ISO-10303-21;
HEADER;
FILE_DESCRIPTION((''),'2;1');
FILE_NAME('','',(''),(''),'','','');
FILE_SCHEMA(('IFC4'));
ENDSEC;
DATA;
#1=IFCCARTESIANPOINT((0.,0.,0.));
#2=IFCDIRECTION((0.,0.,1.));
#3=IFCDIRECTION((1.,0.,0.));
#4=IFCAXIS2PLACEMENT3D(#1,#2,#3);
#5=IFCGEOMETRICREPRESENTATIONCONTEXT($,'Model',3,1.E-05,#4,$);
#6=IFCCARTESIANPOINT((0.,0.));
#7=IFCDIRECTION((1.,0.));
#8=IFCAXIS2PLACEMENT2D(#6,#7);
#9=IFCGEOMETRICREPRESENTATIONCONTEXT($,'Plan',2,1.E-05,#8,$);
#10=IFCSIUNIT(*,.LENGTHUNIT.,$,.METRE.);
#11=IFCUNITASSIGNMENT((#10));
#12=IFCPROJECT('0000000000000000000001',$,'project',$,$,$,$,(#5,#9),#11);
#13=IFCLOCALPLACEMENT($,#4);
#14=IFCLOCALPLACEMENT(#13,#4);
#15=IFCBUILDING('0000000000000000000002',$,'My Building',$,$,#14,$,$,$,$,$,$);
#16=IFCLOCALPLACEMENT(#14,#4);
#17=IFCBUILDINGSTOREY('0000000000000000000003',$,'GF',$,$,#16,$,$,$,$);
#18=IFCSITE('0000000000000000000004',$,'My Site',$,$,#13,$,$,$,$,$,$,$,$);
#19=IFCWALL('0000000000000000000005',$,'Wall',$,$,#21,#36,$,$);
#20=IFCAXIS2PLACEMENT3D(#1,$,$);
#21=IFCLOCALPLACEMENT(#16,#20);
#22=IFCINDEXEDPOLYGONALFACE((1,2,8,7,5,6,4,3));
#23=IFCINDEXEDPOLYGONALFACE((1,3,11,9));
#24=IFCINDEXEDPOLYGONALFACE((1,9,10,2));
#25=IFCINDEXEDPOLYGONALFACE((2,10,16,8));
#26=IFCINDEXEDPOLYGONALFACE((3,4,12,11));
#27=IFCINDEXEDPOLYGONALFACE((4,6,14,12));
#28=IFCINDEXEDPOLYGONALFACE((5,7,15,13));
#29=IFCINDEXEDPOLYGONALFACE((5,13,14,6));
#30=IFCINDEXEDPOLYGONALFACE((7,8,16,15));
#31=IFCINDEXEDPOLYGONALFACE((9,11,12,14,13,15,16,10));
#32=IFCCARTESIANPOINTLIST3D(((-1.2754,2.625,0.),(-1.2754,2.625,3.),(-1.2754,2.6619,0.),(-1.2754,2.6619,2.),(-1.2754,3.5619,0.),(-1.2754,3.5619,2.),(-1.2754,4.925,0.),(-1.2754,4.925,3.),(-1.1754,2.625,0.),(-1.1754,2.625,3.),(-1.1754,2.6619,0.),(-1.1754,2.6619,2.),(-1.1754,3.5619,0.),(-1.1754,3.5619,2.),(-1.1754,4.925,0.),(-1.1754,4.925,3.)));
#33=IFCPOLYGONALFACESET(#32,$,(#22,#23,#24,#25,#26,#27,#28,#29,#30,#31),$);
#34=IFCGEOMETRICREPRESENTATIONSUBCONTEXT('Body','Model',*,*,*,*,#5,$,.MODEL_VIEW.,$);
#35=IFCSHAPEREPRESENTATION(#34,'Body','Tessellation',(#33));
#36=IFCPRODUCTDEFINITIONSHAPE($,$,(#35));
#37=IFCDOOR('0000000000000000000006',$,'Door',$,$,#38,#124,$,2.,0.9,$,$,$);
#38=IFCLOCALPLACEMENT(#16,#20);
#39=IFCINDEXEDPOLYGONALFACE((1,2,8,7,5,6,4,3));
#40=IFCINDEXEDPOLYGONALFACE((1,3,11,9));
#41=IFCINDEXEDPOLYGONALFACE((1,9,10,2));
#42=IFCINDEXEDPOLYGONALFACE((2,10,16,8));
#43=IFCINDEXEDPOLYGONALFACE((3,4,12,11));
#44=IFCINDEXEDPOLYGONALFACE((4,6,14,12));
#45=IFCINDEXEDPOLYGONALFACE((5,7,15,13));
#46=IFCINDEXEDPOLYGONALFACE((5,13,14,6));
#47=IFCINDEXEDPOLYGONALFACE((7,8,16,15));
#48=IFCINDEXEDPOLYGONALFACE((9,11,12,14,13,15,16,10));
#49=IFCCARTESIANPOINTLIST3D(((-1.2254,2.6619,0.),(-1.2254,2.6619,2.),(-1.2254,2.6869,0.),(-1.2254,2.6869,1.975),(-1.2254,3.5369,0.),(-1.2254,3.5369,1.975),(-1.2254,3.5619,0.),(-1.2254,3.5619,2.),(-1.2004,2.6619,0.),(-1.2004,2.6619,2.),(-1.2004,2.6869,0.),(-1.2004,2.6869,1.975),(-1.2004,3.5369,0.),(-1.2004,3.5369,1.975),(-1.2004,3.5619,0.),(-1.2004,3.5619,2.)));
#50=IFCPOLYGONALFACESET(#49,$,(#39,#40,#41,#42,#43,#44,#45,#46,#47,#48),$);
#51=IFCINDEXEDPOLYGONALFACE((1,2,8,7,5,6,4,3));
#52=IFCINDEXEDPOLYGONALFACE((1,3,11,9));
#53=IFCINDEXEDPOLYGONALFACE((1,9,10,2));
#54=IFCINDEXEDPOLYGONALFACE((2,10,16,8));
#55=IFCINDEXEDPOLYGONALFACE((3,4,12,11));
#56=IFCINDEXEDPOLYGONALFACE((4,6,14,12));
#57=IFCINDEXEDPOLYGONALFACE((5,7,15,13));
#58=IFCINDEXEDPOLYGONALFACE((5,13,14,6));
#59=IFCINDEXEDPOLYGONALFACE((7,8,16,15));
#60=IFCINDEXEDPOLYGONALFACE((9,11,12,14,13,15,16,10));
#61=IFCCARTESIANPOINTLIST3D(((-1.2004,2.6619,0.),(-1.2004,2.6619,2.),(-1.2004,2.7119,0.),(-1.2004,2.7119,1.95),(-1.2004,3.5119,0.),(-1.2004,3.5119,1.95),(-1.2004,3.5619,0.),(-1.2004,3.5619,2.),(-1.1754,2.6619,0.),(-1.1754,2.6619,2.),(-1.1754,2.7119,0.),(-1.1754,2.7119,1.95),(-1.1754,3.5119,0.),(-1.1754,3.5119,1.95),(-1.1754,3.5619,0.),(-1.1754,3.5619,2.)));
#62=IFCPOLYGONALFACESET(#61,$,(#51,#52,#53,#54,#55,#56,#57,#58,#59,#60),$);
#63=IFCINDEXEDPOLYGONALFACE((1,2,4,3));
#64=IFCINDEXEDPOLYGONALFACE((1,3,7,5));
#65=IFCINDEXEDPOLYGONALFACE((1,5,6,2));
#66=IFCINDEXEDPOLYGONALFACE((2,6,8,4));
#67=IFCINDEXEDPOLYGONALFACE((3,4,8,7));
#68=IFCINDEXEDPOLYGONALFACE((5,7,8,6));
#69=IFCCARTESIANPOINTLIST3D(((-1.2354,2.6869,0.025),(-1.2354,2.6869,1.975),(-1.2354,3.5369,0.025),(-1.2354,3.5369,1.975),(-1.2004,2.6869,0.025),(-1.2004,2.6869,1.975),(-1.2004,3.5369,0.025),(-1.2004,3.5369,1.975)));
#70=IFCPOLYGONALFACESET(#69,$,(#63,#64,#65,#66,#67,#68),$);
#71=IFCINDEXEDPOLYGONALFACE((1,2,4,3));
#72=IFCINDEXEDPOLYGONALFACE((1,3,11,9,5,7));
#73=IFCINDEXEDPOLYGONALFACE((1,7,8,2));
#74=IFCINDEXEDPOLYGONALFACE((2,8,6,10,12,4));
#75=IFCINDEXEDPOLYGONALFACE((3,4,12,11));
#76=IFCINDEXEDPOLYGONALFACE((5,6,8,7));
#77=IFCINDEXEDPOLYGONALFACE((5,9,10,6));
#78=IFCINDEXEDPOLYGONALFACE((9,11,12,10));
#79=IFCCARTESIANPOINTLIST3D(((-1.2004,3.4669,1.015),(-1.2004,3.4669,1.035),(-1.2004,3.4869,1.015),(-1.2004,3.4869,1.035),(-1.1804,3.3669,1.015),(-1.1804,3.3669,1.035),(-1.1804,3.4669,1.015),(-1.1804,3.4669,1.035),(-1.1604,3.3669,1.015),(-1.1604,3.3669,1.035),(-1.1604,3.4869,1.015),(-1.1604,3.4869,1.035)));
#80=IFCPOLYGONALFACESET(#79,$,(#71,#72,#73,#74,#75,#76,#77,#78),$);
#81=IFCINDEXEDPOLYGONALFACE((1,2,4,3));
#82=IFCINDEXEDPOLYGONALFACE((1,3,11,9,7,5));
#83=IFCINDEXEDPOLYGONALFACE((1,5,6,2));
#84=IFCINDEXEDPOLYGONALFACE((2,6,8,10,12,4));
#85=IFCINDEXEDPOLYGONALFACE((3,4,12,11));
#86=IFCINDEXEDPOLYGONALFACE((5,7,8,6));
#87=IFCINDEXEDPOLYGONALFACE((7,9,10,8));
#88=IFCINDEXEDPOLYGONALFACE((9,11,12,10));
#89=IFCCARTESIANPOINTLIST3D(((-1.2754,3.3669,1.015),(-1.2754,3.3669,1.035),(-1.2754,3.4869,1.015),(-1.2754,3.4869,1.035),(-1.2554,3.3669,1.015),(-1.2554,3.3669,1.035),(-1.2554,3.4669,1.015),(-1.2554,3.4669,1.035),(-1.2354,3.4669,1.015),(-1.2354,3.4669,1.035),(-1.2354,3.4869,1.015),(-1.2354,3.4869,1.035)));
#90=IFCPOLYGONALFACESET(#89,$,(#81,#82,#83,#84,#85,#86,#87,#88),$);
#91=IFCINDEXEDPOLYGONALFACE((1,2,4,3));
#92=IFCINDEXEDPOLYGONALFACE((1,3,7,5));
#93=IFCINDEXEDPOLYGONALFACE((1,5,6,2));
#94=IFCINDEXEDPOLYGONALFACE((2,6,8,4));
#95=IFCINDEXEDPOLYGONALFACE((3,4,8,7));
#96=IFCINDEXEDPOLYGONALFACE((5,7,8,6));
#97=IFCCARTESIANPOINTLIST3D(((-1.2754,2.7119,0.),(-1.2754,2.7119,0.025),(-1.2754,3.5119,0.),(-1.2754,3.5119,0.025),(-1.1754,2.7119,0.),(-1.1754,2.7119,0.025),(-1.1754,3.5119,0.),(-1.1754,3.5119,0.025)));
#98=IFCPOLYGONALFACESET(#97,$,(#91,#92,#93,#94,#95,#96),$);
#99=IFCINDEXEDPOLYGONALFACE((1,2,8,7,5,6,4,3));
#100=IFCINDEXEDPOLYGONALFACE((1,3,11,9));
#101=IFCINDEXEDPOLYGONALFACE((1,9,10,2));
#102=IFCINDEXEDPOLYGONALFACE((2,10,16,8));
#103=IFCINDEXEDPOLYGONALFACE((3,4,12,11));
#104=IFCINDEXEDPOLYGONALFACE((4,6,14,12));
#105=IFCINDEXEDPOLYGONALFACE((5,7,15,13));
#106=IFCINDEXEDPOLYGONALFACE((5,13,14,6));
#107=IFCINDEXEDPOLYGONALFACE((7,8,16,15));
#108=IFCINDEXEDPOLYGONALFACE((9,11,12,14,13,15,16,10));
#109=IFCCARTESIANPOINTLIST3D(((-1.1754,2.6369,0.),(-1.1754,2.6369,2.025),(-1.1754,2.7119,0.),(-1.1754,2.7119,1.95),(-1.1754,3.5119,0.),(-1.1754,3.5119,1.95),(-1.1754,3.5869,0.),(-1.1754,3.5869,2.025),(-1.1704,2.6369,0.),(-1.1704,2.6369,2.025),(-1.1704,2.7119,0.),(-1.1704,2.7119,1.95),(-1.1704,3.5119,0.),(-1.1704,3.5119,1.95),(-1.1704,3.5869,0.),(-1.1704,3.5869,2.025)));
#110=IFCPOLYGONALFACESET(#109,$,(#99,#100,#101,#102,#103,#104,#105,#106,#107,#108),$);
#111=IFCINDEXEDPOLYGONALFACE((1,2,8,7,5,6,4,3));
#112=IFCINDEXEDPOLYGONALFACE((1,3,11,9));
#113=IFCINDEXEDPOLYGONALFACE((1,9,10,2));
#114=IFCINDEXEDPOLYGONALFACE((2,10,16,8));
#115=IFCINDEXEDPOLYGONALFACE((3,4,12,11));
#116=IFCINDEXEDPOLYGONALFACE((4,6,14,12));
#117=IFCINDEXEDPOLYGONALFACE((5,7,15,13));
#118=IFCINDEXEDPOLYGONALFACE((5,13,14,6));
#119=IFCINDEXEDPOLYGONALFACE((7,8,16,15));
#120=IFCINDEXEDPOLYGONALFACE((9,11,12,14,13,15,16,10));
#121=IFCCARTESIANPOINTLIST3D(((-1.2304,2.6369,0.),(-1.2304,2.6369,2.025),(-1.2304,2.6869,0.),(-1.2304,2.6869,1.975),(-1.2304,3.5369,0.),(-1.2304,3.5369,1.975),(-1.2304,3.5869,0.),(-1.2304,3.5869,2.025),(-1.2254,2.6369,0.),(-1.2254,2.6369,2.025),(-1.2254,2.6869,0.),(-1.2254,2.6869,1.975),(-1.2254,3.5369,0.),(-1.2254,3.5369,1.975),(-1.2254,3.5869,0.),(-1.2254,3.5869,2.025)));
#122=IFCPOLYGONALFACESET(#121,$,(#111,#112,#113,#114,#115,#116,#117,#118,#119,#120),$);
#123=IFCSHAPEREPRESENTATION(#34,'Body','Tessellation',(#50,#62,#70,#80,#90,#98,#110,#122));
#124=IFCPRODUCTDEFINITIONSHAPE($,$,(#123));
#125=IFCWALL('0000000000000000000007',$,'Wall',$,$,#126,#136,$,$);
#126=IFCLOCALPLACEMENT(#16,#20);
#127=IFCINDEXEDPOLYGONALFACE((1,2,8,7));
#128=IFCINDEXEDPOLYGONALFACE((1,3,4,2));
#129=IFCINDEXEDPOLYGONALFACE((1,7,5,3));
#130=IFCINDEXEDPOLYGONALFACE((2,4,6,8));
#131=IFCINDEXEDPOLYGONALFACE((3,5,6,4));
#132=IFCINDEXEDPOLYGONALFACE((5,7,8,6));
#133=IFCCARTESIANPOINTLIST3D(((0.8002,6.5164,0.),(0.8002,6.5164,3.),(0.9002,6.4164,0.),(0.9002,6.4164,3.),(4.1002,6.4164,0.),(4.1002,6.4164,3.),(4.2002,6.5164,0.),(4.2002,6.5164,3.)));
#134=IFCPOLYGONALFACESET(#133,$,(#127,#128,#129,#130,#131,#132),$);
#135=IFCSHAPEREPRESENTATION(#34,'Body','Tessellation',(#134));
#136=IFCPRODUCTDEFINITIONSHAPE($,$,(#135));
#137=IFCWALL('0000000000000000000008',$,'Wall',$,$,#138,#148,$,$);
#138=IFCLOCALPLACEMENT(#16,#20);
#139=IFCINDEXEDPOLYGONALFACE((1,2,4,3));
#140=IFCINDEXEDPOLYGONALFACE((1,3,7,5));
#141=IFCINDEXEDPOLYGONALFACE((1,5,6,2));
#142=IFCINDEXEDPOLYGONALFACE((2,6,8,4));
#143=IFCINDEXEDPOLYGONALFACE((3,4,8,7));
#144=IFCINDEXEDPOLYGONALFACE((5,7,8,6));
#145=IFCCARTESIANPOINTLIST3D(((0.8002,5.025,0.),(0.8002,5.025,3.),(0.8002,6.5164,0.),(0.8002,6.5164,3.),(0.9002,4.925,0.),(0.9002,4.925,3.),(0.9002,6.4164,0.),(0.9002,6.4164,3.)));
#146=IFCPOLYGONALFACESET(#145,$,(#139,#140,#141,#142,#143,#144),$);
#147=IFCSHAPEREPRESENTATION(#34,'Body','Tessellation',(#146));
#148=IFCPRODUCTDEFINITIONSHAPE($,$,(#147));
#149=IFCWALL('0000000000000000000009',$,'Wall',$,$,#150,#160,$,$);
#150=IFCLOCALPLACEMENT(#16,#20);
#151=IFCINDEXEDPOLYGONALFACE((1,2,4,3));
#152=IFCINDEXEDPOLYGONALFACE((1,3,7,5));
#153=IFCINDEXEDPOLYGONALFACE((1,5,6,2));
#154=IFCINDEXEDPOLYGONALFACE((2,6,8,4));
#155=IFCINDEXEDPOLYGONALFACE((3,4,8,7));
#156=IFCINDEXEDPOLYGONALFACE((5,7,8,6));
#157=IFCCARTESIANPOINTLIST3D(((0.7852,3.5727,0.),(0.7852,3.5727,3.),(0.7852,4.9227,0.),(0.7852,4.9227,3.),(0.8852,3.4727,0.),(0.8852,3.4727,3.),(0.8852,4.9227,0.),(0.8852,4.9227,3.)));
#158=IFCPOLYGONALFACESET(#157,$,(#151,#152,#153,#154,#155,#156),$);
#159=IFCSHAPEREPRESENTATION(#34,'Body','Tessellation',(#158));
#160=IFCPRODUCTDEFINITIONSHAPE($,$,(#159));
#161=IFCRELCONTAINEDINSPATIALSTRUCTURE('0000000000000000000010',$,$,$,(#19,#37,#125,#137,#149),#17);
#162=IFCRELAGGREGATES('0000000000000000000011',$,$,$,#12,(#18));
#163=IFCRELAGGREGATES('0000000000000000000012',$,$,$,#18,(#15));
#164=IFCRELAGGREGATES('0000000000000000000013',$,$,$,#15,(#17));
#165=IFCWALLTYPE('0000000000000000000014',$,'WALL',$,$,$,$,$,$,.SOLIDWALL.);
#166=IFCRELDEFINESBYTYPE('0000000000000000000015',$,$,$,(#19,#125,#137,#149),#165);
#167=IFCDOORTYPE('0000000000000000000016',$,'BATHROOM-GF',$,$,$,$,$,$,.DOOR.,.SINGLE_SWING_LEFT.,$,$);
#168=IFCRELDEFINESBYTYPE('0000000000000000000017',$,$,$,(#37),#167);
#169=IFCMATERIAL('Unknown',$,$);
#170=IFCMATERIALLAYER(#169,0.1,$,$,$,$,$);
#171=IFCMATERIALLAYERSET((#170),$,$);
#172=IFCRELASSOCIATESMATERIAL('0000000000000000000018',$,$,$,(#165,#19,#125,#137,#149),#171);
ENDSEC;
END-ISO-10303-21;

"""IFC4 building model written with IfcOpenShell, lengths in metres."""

from ifc_helpers import new_model, entity, si_unit, frame, origin_with_axes, origin_2d_with_axis, place, context, subcontext, project, spatial, line, indexed_curve, outline, extrude, shape, source, transform, mapped, material, layer, layer_set, layer_usage, type_object, type_shapes, element, fill, save


model = new_model("IFC4")

# Units and contexts
model_context = context("Model", 3, precision=1e-05, world=origin_with_axes())
plan_context = context("Plan", 2, precision=1e-05, world=origin_2d_with_axis())
body_context_1 = subcontext(model_context, "Body", "Model", "MODEL_VIEW")
body_context_2 = subcontext(plan_context, "Body", "Plan", "PLAN_VIEW")
ifc_project = project(units=[si_unit("LENGTHUNIT", "METRE")], contexts=[model_context, plan_context])

# Site, building, storey
site_placement = place(None, origin_with_axes())
site = spatial("IfcSite", under=ifc_project, at=site_placement, Name="My Site")
building_placement = place(site_placement, origin_with_axes())
building = spatial("IfcBuilding", under=site, at=building_placement, Name="My Building")
storey_placement = place(building_placement, origin_with_axes())
storey = spatial("IfcBuildingStorey", under=building, at=storey_placement, Name="GF")

# Shared definitions
ifc_material_1 = material(Name="Unknown")

# Shared definitions
ifc_layer_1 = layer(ifc_material_1, 0.1)
ifc_layer_set_1 = layer_set([ifc_layer_1])
wall_type = type_object("IfcWallType", Name="WALL", PredefinedType="SOLIDWALL", material=ifc_layer_set_1)

# Wall, opening, door
ifc_layer_usage_1 = layer_usage(ifc_layer_set_1, "AXIS2", "POSITIVE", 0.0)
wall_1_placement = place(storey_placement, frame((-1.1754, 2.625, 0.0), z_axis=(0.0, 0.0, 1.0), x_axis=(0.0, 1.0, 0.0)))
wall_1 = element("IfcWall", 1, at=wall_1_placement, inside=storey, type_object=wall_type, material=ifc_layer_usage_1, Name="Wall", context=body_context_1, shape_type="SweptSolid", body=[
    extrude(outline(indexed_curve([(0.0, 0.0), (0.0, 0.1), (2.3, 0.1), (2.3, 0.0)], segments=[line(1, 2, 3, 4, 1)])), origin_with_axes(), (0.0, 0.0, 1.0), 3.0),
])
shared_shape_1 = source(origin_with_axes(), body_context_1, "Body", "SweptSolid", [
    extrude(outline(indexed_curve([(0.0, 0.0), (0.9, 0.0), (0.9, 2.0), (0.0, 2.0)], segments=[line(1, 2, 3, 4, 1)])), frame((0.0, -0.6, 0.0), z_axis=(0.0, -1.0, 0.0), x_axis=(1.0, 0.0, 0.0)), (0.0, 0.0, -1.0), 1.2),
])
opening_1_placement = place(wall_1_placement, frame((0.0369, 0.0, 0.0), z_axis=(0.0, 0.0, 1.0), x_axis=(1.0, 0.0, 0.0)))
opening_1 = element("IfcOpeningElement", 2, at=opening_1_placement, cuts=wall_1, PredefinedType="OPENING", context=body_context_1, shape_type="MappedRepresentation", body=[
    mapped(shared_shape_1, transform((0.0, 0.0, 0.0), x_axis=(1.0, 0.0, 0.0), y_axis=(0.0, 1.0, 0.0), z_axis=(0.0, 0.0, 1.0), scale=1.0)),
])
door_type_1 = type_object("IfcDoorType", Name="BATHROOM-GF", OperationType="SINGLE_SWING_LEFT", PredefinedType="DOOR")
shared_shape_2 = source(origin_with_axes(), body_context_1, "Body", "SweptSolid", [
    extrude(outline(indexed_curve([(0.0, 0.0), (0.0, 2.0), (0.9, 2.0), (0.9, 0.0), (0.875, 0.0), (0.875, 1.975), (0.025, 1.975), (0.025, 0.0)], segments=[line(1, 2, 3, 4, 5, 6, 7, 8, 1)])), frame((0.0, 0.025, 0.0), z_axis=(0.0, -1.0, 0.0), x_axis=(1.0, 0.0, 0.0)), (0.0, 0.0, -1.0), 0.025),
    extrude(outline(indexed_curve([(0.0, 0.0), (0.0, 2.0), (0.9, 2.0), (0.9, 0.0), (0.85, 0.0), (0.85, 1.95), (0.05, 1.95), (0.05, 0.0)], segments=[line(1, 2, 3, 4, 5, 6, 7, 8, 1)])), frame((0.0, 0.0, 0.0), z_axis=(0.0, -1.0, 0.0), x_axis=(1.0, 0.0, 0.0)), (0.0, 0.0, -1.0), 0.025),
    extrude(outline(indexed_curve([(0.0, 0.0), (0.85, 0.0), (0.85, 0.035), (0.0, 0.035)], segments=[line(1, 2, 3, 4, 1)])), frame((0.025, 0.025, 0.025), z_axis=(0.0, 0.0, 1.0), x_axis=(1.0, 0.0, 0.0)), (0.0, 0.0, 1.0), 1.95),
    extrude(outline(indexed_curve([(0.0, 0.0), (0.0, -0.04), (-0.12, -0.04), (-0.12, -0.02), (-0.02, -0.02), (-0.02, 0.0)], segments=[line(1, 2, 3, 4, 5, 6, 1)])), frame((0.825, 0.025, 1.015), z_axis=(0.0, 0.0, 1.0), x_axis=(1.0, 0.0, 0.0)), (0.0, 0.0, 1.0), 0.02),
    extrude(outline(indexed_curve([(0.0, 0.0), (0.0, 0.04), (-0.12, 0.04), (-0.12, 0.02), (-0.02, 0.02), (-0.02, 0.0)], segments=[line(1, 2, 3, 4, 5, 6, 1)])), frame((0.825, 0.06, 1.015), z_axis=(0.0, 0.0, 1.0), x_axis=(1.0, 0.0, 0.0)), (0.0, 0.0, 1.0), 0.02),
    extrude(outline(indexed_curve([(0.0, 0.0), (0.8, 0.0), (0.8, 0.1), (0.0, 0.1)], segments=[line(1, 2, 3, 4, 1)])), frame((0.05, 0.0, 0.0), z_axis=(0.0, 0.0, 1.0), x_axis=(1.0, 0.0, 0.0)), (0.0, 0.0, 1.0), 0.025),
    extrude(outline(indexed_curve([(0.0, 0.0), (0.0, 2.025), (0.95, 2.025), (0.95, 0.0), (0.875, 0.0), (0.875, 1.95), (0.075, 1.95), (0.075, 0.0)], segments=[line(1, 2, 3, 4, 5, 6, 7, 8, 1)])), frame((-0.025, -0.005, 0.0), z_axis=(0.0, -1.0, 0.0), x_axis=(1.0, 0.0, 0.0)), (0.0, 0.0, -1.0), 0.005),
    extrude(outline(indexed_curve([(0.0, 0.0), (0.0, 2.025), (0.95, 2.025), (0.95, 0.0), (0.9, 0.0), (0.9, 1.975), (0.05, 1.975), (0.05, 0.0)], segments=[line(1, 2, 3, 4, 5, 6, 7, 8, 1)])), frame((-0.025, 0.05, 0.0), z_axis=(0.0, -1.0, 0.0), x_axis=(1.0, 0.0, 0.0)), (0.0, 0.0, -1.0), 0.005),
])
shared_shape_3 = source(origin_with_axes(), body_context_2, "Body", "Curve2D", [
    entity("IfcIndexedPolyCurve", entity("IfcCartesianPointList2D", [[0.0, 0.0], [0.0, 0.05], [0.025, 0.05], [0.025, 0.025], [0.05, 0.025], [0.05, 0.0]]), [entity("IfcLineIndex", [1, 2, 3, 4, 5, 6, 1])]),
    entity("IfcIndexedPolyCurve", entity("IfcCartesianPointList2D", [[0.9, 0.0], [0.9, 0.05], [0.875, 0.05], [0.875, 0.025], [0.85, 0.025], [0.85, 0.0]]), [entity("IfcLineIndex", [1, 2, 3, 4, 5, 6, 1])]),
    entity("IfcTrimmedCurve", entity("IfcEllipse", entity("IfcAxis2Placement2D", entity("IfcCartesianPoint", [0.06, 0.05]), entity("IfcDirection", [1.0, 0.0])), 0.815, 0.85), [entity("IfcCartesianPoint", [0.875, 0.05])], [entity("IfcCartesianPoint", [0.06, 0.9])], True, "CARTESIAN"),
    entity("IfcIndexedPolyCurve", entity("IfcCartesianPointList2D", [[0.025, 0.05], [0.06, 0.05], [0.06, 0.9], [0.025, 0.9]]), [entity("IfcLineIndex", [1, 2, 3, 4, 1])]),
])
type_shapes(door_type_1, [shared_shape_2, shared_shape_3])
door_1_placement = place(opening_1_placement, frame((0.0, 0.0, 0.0), z_axis=(0.0, 0.0, 1.0), x_axis=(1.0, 0.0, 0.0)))
door_1 = element("IfcDoor", 3, at=door_1_placement, inside=storey, type_object=door_type_1, Name="Door", OverallHeight=2.0, OverallWidth=0.9, shapes=[
    shape(body_context_1, "Body", "MappedRepresentation", [mapped(shared_shape_2, transform((0.0, 0.0, 0.0), x_axis=(1.0, 0.0, 0.0), y_axis=(0.0, 1.0, 0.0), z_axis=(0.0, 0.0, 1.0), scale=1.0))]),
    shape(body_context_2, "Body", "MappedRepresentation", [mapped(shared_shape_3, transform((0.0, 0.0, 0.0), x_axis=(1.0, 0.0, 0.0), y_axis=(0.0, 1.0, 0.0), z_axis=(0.0, 0.0, 1.0), scale=1.0))]),
])
fill(opening_1, door_1)

# Walls
ifc_layer_usage_2 = layer_usage(ifc_layer_set_1, "AXIS2", "POSITIVE", 0.0)
wall_2_placement = place(storey_placement, frame((4.2002, 6.5164, 0.0), z_axis=(0.0, 0.0, 1.0), x_axis=(-1.0, 0.0, 0.0)))
element("IfcWall", 4, at=wall_2_placement, inside=storey, type_object=wall_type, material=ifc_layer_usage_2, Name="Wall", context=body_context_1, shape_type="SweptSolid", body=[
    extrude(outline(indexed_curve([(0.0, 0.0), (0.1, 0.1), (3.3, 0.1), (3.4, 0.0)], segments=[line(1, 2, 3, 4, 1)])), origin_with_axes(), (0.0, 0.0, 1.0), 3.0),
])
ifc_layer_usage_3 = layer_usage(ifc_layer_set_1, "AXIS2", "POSITIVE", 0.0)
wall_3_placement = place(storey_placement, frame((0.8002, 6.5164, 0.0), z_axis=(0.0, 0.0, 1.0), x_axis=(0.0, -1.0, 0.0)))
element("IfcWall", 5, at=wall_3_placement, inside=storey, type_object=wall_type, material=ifc_layer_usage_3, Name="Wall", context=body_context_1, shape_type="SweptSolid", body=[
    extrude(outline(indexed_curve([(0.0, 0.0), (0.1, 0.1), (1.5914, 0.1), (1.4914, 0.0)], segments=[line(1, 2, 3, 4, 1)])), origin_with_axes(), (0.0, 0.0, 1.0), 3.0),
])
ifc_layer_usage_4 = layer_usage(ifc_layer_set_1, "AXIS2", "POSITIVE", 0.0)
wall_4_placement = place(storey_placement, frame((0.7852, 4.9227, 0.0), z_axis=(0.0, 0.0, 1.0), x_axis=(0.0, -1.0, 0.0)))
element("IfcWall", 6, at=wall_4_placement, inside=storey, type_object=wall_type, material=ifc_layer_usage_4, Name="Wall", context=body_context_1, shape_type="SweptSolid", body=[
    extrude(outline(indexed_curve([(0.0, 0.0), (0.0, 0.1), (1.45, 0.1), (1.35, 0.0)], segments=[line(1, 2, 3, 4, 1)])), origin_with_axes(), (0.0, 0.0, 1.0), 3.0),
])

save(model, "model.ifc")
